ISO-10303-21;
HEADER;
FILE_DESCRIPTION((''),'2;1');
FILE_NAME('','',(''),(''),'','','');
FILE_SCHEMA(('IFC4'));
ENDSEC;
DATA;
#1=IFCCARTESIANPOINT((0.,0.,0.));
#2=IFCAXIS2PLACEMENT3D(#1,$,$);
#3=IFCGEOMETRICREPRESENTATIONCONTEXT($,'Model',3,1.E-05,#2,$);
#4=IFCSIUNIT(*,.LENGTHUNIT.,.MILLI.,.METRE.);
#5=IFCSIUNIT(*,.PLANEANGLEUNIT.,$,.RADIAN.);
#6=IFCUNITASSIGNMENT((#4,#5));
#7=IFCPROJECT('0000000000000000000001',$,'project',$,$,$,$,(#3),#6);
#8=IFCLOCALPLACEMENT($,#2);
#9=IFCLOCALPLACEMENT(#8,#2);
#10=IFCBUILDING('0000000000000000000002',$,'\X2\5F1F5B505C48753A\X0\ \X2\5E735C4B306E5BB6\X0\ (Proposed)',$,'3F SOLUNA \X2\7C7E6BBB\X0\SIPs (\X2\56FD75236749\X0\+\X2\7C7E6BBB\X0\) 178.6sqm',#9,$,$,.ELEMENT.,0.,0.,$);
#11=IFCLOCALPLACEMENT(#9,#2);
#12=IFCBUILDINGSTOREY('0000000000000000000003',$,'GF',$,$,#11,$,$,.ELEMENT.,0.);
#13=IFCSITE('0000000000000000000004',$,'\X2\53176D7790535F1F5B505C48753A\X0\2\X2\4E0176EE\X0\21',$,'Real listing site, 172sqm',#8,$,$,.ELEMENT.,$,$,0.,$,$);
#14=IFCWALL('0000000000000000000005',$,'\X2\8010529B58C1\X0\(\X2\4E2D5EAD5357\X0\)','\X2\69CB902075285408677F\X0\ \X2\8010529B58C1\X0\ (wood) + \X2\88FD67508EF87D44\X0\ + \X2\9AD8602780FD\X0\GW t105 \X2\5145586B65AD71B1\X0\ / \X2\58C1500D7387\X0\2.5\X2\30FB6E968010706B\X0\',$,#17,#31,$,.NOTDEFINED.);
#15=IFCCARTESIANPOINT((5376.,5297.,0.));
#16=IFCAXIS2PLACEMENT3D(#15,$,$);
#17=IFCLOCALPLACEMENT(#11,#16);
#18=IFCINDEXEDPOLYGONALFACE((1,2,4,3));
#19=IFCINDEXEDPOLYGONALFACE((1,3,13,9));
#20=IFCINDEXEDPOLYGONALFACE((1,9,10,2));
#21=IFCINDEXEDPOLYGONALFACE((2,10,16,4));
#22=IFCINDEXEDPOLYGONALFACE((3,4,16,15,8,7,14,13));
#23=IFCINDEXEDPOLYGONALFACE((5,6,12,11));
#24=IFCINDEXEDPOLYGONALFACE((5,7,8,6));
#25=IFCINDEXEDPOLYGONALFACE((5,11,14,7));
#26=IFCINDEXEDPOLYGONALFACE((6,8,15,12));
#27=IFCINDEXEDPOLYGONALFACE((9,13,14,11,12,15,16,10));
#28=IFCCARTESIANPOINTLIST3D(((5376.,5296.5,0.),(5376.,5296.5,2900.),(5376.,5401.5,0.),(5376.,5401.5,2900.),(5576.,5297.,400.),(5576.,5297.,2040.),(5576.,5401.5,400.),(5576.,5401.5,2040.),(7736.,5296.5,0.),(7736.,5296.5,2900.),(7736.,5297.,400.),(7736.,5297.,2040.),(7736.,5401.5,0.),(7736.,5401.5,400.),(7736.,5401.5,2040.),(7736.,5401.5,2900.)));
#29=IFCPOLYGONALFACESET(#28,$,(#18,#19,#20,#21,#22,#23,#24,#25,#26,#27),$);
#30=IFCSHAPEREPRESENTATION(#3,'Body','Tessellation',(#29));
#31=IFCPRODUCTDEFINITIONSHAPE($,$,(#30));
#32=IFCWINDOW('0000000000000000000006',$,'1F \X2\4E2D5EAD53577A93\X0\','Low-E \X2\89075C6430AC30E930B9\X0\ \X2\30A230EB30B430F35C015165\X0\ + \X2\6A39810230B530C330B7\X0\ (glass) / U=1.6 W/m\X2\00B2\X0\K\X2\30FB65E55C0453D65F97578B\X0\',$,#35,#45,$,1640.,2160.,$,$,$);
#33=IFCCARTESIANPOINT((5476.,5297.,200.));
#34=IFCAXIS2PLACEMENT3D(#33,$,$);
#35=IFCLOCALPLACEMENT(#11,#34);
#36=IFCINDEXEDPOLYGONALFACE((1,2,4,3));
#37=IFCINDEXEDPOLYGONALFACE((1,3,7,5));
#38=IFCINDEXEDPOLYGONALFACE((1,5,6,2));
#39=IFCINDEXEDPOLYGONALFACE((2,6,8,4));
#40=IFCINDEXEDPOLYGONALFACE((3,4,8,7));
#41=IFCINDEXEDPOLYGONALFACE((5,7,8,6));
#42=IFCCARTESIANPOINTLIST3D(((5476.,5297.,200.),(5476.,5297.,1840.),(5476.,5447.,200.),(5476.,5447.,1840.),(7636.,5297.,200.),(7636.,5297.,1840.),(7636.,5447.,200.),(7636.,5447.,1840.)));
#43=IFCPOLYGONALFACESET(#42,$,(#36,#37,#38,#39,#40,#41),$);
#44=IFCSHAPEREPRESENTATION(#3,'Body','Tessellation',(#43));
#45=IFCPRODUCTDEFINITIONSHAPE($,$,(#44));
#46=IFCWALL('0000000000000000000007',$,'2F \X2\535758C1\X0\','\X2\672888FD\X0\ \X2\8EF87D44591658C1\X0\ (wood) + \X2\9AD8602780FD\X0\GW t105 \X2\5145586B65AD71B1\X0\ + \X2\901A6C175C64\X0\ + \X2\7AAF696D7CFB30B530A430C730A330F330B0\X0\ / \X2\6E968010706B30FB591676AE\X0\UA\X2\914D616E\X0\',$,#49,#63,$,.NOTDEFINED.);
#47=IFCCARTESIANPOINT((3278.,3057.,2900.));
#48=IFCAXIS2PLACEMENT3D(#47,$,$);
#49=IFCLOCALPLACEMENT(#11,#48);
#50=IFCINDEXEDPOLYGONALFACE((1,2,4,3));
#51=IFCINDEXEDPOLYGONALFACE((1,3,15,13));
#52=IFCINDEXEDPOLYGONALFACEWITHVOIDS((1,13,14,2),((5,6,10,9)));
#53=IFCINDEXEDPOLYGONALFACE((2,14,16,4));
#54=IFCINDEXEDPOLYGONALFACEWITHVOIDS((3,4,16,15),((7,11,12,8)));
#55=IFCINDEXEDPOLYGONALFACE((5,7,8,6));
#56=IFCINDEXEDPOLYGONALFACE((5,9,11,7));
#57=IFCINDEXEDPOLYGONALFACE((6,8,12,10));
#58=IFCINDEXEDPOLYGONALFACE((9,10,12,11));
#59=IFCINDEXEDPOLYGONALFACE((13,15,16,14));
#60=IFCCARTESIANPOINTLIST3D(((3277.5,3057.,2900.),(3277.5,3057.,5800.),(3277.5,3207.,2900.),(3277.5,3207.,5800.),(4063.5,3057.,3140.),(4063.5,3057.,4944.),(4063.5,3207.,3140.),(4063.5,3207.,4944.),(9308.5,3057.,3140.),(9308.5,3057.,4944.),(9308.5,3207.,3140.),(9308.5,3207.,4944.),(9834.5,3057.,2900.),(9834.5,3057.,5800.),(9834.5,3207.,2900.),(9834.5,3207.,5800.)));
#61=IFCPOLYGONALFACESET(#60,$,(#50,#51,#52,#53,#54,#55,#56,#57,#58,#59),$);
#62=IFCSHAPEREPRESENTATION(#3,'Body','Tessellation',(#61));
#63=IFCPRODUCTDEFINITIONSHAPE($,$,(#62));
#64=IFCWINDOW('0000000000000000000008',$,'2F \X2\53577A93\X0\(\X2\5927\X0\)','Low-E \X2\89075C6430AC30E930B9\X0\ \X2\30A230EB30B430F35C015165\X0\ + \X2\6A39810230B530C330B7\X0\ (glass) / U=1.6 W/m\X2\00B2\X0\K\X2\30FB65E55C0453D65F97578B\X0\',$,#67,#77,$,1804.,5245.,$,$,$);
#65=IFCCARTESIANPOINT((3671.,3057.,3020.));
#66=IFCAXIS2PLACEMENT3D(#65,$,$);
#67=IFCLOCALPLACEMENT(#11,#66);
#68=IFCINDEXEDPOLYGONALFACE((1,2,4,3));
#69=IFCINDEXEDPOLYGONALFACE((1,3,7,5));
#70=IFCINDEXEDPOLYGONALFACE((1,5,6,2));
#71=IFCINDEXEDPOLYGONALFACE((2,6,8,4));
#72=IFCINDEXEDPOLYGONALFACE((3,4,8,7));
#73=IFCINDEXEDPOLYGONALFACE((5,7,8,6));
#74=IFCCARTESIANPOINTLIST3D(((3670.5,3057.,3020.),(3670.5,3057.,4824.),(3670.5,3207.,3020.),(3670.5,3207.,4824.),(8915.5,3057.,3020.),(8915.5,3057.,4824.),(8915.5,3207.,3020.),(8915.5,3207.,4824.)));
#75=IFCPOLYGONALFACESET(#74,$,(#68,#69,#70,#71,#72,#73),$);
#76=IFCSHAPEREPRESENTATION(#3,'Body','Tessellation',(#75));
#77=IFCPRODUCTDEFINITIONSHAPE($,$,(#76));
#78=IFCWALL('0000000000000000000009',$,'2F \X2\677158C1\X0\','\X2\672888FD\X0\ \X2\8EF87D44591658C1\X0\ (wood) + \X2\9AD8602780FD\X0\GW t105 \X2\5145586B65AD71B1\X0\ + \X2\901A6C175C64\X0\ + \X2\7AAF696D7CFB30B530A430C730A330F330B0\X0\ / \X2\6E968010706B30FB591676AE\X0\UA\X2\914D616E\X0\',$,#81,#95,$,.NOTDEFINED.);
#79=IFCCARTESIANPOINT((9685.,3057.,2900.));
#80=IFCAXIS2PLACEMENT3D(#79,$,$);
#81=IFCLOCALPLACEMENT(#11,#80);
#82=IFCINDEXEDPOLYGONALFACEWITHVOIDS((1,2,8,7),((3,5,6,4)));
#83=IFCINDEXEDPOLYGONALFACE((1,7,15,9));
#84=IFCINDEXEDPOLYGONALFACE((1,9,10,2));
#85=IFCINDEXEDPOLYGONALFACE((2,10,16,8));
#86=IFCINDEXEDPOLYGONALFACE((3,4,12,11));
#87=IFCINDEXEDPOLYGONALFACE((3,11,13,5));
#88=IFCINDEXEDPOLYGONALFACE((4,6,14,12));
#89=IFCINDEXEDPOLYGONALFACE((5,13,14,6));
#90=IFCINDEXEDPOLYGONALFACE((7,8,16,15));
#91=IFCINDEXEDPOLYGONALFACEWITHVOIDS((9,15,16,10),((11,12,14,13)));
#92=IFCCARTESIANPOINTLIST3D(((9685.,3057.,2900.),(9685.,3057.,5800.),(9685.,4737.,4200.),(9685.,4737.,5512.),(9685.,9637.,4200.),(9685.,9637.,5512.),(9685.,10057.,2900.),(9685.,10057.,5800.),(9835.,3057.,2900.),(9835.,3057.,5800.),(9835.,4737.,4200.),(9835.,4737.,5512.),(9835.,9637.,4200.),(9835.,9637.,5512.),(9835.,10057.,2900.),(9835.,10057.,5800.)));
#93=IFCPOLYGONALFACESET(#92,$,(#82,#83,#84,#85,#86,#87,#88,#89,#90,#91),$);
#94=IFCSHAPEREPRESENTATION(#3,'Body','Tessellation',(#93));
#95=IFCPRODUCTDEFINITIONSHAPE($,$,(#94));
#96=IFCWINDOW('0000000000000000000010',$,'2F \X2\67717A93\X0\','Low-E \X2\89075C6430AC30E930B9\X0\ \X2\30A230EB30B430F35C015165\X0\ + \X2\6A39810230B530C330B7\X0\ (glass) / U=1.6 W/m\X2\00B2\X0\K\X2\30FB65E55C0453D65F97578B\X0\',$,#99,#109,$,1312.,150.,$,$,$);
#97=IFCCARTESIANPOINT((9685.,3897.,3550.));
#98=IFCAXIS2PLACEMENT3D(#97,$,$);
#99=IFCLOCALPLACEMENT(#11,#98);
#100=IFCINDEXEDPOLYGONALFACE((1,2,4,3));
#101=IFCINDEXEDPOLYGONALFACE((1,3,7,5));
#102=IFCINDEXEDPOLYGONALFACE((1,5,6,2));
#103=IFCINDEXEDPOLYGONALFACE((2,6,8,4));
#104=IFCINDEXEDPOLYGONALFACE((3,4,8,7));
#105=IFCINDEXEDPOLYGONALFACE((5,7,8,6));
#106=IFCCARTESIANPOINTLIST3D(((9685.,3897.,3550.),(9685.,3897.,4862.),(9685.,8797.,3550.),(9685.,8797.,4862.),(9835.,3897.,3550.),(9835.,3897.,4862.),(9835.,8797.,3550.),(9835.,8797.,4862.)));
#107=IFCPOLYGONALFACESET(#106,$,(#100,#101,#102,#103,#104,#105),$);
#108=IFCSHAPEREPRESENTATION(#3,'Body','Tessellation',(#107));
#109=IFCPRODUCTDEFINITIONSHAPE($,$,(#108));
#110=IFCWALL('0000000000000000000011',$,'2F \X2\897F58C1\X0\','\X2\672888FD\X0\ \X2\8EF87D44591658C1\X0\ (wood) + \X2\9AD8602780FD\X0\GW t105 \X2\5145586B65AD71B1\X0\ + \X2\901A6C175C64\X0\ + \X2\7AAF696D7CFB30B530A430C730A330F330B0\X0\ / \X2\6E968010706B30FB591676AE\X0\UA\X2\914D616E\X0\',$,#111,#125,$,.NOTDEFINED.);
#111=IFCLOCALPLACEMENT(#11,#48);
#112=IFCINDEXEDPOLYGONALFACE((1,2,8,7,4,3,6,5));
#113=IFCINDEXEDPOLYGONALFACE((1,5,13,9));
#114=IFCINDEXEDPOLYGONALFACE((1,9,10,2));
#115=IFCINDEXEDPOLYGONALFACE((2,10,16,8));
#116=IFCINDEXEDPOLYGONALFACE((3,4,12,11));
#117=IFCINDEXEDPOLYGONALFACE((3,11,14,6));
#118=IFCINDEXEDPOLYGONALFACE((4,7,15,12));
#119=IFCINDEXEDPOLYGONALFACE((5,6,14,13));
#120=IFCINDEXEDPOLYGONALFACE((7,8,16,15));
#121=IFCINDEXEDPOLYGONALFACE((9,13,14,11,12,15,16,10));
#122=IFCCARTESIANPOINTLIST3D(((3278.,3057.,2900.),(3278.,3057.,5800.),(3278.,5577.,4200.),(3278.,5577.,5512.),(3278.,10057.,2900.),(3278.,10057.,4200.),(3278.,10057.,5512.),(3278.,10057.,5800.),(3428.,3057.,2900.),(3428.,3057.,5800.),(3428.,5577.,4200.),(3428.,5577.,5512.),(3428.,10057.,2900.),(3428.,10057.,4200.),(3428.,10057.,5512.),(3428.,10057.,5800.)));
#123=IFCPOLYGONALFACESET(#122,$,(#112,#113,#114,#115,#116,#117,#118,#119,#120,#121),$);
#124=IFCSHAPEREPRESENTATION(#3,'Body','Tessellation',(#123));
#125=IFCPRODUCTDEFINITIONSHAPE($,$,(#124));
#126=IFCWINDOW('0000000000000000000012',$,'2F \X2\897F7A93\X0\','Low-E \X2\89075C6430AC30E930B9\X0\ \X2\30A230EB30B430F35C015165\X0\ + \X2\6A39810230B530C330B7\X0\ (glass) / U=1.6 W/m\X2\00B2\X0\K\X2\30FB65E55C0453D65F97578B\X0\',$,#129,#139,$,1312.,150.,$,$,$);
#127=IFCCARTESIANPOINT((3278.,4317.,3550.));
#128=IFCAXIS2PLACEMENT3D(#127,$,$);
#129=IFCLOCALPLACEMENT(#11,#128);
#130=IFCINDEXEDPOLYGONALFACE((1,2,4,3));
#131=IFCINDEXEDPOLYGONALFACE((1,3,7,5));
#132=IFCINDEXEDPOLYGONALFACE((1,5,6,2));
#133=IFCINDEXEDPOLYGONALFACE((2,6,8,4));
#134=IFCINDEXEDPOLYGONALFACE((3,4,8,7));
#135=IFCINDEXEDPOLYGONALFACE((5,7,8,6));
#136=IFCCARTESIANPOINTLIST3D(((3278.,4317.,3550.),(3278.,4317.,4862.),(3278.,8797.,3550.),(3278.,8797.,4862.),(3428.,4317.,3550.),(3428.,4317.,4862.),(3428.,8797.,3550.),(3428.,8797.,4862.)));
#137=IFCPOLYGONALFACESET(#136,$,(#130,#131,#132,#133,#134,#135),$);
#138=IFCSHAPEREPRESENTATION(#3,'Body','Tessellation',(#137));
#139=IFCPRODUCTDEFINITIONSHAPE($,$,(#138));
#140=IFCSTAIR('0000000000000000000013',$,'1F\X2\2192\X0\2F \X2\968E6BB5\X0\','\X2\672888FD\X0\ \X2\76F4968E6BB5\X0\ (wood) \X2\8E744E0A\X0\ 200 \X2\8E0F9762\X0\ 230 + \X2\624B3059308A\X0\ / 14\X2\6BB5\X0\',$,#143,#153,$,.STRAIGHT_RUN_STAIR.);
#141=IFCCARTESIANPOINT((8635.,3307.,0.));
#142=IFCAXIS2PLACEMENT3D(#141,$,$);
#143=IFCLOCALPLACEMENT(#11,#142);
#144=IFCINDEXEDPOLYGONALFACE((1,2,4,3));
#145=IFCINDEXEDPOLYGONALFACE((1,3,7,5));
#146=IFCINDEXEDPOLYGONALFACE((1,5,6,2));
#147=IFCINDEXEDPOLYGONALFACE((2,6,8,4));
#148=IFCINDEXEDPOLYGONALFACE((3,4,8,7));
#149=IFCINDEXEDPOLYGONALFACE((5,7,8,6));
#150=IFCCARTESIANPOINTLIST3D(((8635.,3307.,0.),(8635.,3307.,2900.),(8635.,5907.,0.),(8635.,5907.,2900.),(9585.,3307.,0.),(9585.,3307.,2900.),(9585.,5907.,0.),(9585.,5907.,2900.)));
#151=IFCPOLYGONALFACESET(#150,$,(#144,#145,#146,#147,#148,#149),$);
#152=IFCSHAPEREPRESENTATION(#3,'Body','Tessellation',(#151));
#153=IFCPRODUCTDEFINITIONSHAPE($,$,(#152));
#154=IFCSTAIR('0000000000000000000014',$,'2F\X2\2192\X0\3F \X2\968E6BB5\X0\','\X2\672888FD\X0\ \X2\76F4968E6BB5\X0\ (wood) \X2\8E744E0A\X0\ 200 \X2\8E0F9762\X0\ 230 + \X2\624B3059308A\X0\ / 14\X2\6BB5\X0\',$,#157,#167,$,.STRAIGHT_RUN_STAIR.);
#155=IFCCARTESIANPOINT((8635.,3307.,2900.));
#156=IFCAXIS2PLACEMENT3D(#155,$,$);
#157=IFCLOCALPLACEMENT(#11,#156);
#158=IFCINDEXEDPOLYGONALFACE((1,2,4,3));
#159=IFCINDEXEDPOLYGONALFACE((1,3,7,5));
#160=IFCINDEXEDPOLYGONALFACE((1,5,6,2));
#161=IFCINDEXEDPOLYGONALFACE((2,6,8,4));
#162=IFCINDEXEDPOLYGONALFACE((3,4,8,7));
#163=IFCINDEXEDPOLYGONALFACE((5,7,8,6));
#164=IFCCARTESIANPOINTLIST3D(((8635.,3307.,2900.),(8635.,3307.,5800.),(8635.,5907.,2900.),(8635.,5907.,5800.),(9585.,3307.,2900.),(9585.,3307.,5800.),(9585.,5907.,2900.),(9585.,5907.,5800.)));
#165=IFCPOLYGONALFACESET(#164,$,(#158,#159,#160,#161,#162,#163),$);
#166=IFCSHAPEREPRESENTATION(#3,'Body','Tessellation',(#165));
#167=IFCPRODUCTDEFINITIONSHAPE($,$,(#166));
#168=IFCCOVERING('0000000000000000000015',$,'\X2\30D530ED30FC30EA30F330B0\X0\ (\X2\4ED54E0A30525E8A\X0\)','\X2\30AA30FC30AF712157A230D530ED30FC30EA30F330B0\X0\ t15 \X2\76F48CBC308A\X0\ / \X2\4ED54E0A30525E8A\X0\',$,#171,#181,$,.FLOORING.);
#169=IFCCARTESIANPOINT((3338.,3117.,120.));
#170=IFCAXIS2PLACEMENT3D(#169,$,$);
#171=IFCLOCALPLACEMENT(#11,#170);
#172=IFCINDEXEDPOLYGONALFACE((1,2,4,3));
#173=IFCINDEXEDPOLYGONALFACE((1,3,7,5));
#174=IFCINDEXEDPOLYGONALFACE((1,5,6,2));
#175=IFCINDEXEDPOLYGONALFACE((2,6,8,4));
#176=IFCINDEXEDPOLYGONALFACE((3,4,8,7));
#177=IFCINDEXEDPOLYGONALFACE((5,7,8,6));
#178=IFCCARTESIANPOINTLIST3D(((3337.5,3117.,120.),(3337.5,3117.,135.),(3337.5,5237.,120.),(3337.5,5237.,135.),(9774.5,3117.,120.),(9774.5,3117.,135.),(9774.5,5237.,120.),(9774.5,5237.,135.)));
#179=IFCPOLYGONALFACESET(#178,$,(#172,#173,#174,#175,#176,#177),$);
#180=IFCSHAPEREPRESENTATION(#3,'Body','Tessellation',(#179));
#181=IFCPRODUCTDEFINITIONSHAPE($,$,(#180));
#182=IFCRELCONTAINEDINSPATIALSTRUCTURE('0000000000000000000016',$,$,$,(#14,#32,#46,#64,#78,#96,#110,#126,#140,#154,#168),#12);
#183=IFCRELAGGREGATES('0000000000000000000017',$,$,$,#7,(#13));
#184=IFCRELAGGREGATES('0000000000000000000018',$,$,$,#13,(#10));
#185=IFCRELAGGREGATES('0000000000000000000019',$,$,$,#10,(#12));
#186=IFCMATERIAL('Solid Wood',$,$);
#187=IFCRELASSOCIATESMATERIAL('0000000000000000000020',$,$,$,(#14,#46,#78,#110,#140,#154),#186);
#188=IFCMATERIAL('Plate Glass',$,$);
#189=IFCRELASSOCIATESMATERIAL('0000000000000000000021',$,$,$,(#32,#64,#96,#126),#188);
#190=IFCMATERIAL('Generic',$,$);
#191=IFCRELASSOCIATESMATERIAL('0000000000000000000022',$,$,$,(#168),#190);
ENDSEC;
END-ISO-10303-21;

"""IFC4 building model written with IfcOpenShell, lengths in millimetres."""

from ifc_helpers import new_model, si_unit, frame, frame_2d, origin, place, context, project, spatial, rectangle, extrude, material, element, fill, save


model = new_model("IFC4")

# Units and contexts
model_context = context("Model", 3, precision=1e-05, world=origin())
ifc_project = project(units=[si_unit("LENGTHUNIT", "METRE", prefix="MILLI"), si_unit("PLANEANGLEUNIT", "RADIAN")], contexts=[model_context])

# Site, building, storey
site_placement = place(None, origin())
site = spatial("IfcSite", under=ifc_project, at=site_placement, Name="北海道弟子屈町2丁目21", ObjectType="Real listing site, 172sqm", CompositionType="ELEMENT", RefElevation=0.0)
building_placement = place(site_placement, origin())
building = spatial("IfcBuilding", under=site, at=building_placement, Name="弟子屈町 平屋の家 (Proposed)", ObjectType="3F SOLUNA 籾殻SIPs (国産杉+籾殻) 178.6sqm", CompositionType="ELEMENT", ElevationOfRefHeight=0.0, ElevationOfTerrain=0.0)
storey_placement = place(building_placement, origin())
storey = spatial("IfcBuildingStorey", under=building, at=storey_placement, Name="GF", CompositionType="ELEMENT", Elevation=0.0)

# Shared definitions
ifc_material_1 = material(Name="Solid Wood")
ifc_material_2 = material(Name="Generic")

# Shared definitions
ifc_material_3 = material(Name="Plate Glass")

# Walls, openings, windows
wall_1_placement = place(storey_placement, frame((5376.0, 5297.0, 0.0)))
wall_1 = element("IfcWall", 1, at=wall_1_placement, inside=storey, material=ifc_material_1, Name="耐力壁(中庭南)", Description="構造用合板 耐力壁 (wood) + 製材軸組 + 高性能GW t105 充填断熱 / 壁倍率2.5・準耐火", PredefinedType="NOTDEFINED", context=model_context, shape_type="SweptSolid", body=[
    extrude(rectangle(XDim=2360.0, YDim=105.0, at=frame_2d((1180.0, 52.0))), frame((5376.0, 5297.0, 0.0)), (0.0, 0.0, 1.0), 2900.0),
])
opening_1_placement = place(storey_placement, frame((5476.0, 5297.0, 200.0)))
opening_1 = element("IfcOpeningElement", 2, at=opening_1_placement, cuts=wall_1, PredefinedType="NOTDEFINED", context=model_context, shape_type="SweptSolid", body=[
    extrude(rectangle(XDim=2160.0, YDim=150.0, at=frame_2d((1080.0, 75.0))), frame((5476.0, 5297.0, 200.0)), (0.0, 0.0, 1.0), 1640.0),
])
window_1_placement = place(storey_placement, frame((5476.0, 5297.0, 200.0)))
window_1 = element("IfcWindow", 3, at=window_1_placement, inside=storey, material=ifc_material_3, Name="1F 中庭南窓", Description="Low-E 複層ガラス アルゴン封入 + 樹脂サッシ (glass) / U=1.6 W/m²K・日射取得型", OverallHeight=1640.0, OverallWidth=2160.0, context=model_context, shape_type="SweptSolid", body=[
    extrude(rectangle(XDim=2160.0, YDim=150.0, at=frame_2d((1080.0, 75.0))), frame((5476.0, 5297.0, 200.0)), (0.0, 0.0, 1.0), 1640.0),
])
fill(opening_1, window_1)
wall_2_placement = place(storey_placement, frame((3278.0, 3057.0, 2900.0)))
wall_2 = element("IfcWall", 4, at=wall_2_placement, inside=storey, material=ifc_material_1, Name="2F 南壁", Description="木製 軸組外壁 (wood) + 高性能GW t105 充填断熱 + 通気層 + 窯業系サイディング / 準耐火・外皮UA配慮", PredefinedType="NOTDEFINED", context=model_context, shape_type="SweptSolid", body=[
    extrude(rectangle(XDim=6557.0, YDim=150.0, at=frame_2d((3278.0, 75.0))), frame((3278.0, 3057.0, 2900.0)), (0.0, 0.0, 1.0), 2900.0),
])
opening_2_placement = place(storey_placement, frame((3671.0, 3057.0, 3020.0)))
opening_2 = element("IfcOpeningElement", 5, at=opening_2_placement, cuts=wall_2, PredefinedType="NOTDEFINED", context=model_context, shape_type="SweptSolid", body=[
    extrude(rectangle(XDim=5245.0, YDim=150.0, at=frame_2d((2622.0, 75.0))), frame((3671.0, 3057.0, 3020.0)), (0.0, 0.0, 1.0), 1804.0),
])
window_2_placement = place(storey_placement, frame((3671.0, 3057.0, 3020.0)))
window_2 = element("IfcWindow", 6, at=window_2_placement, inside=storey, material=ifc_material_3, Name="2F 南窓(大)", Description="Low-E 複層ガラス アルゴン封入 + 樹脂サッシ (glass) / U=1.6 W/m²K・日射取得型", OverallHeight=1804.0, OverallWidth=5245.0, context=model_context, shape_type="SweptSolid", body=[
    extrude(rectangle(XDim=5245.0, YDim=150.0, at=frame_2d((2622.0, 75.0))), frame((3671.0, 3057.0, 3020.0)), (0.0, 0.0, 1.0), 1804.0),
])
fill(opening_2, window_2)
wall_3_placement = place(storey_placement, frame((9685.0, 3057.0, 2900.0)))
wall_3 = element("IfcWall", 7, at=wall_3_placement, inside=storey, material=ifc_material_1, Name="2F 東壁", Description="木製 軸組外壁 (wood) + 高性能GW t105 充填断熱 + 通気層 + 窯業系サイディング / 準耐火・外皮UA配慮", PredefinedType="NOTDEFINED", context=model_context, shape_type="SweptSolid", body=[
    extrude(rectangle(XDim=150.0, YDim=7000.0, at=frame_2d((75.0, 3500.0))), frame((9685.0, 3057.0, 2900.0)), (0.0, 0.0, 1.0), 2900.0),
])
opening_3_placement = place(storey_placement, frame((9685.0, 3897.0, 3550.0)))
opening_3 = element("IfcOpeningElement", 8, at=opening_3_placement, cuts=wall_3, PredefinedType="NOTDEFINED", context=model_context, shape_type="SweptSolid", body=[
    extrude(rectangle(XDim=150.0, YDim=4900.0, at=frame_2d((75.0, 2450.0))), frame((9685.0, 3897.0, 3550.0)), (0.0, 0.0, 1.0), 1312.0),
])
window_3_placement = place(storey_placement, frame((9685.0, 3897.0, 3550.0)))
window_3 = element("IfcWindow", 9, at=window_3_placement, inside=storey, material=ifc_material_3, Name="2F 東窓", Description="Low-E 複層ガラス アルゴン封入 + 樹脂サッシ (glass) / U=1.6 W/m²K・日射取得型", OverallHeight=1312.0, OverallWidth=150.0, context=model_context, shape_type="SweptSolid", body=[
    extrude(rectangle(XDim=150.0, YDim=4900.0, at=frame_2d((75.0, 2450.0))), frame((9685.0, 3897.0, 3550.0)), (0.0, 0.0, 1.0), 1312.0),
])
fill(opening_3, window_3)
wall_4_placement = place(storey_placement, frame((3278.0, 3057.0, 2900.0)))
wall_4 = element("IfcWall", 10, at=wall_4_placement, inside=storey, material=ifc_material_1, Name="2F 西壁", Description="木製 軸組外壁 (wood) + 高性能GW t105 充填断熱 + 通気層 + 窯業系サイディング / 準耐火・外皮UA配慮", PredefinedType="NOTDEFINED", context=model_context, shape_type="SweptSolid", body=[
    extrude(rectangle(XDim=150.0, YDim=7000.0, at=frame_2d((75.0, 3500.0))), frame((3278.0, 3057.0, 2900.0)), (0.0, 0.0, 1.0), 2900.0),
])
opening_4_placement = place(storey_placement, frame((3278.0, 4317.0, 3550.0)))
opening_4 = element("IfcOpeningElement", 11, at=opening_4_placement, cuts=wall_4, PredefinedType="NOTDEFINED", context=model_context, shape_type="SweptSolid", body=[
    extrude(rectangle(XDim=150.0, YDim=4480.0, at=frame_2d((75.0, 2240.0))), frame((3278.0, 4317.0, 3550.0)), (0.0, 0.0, 1.0), 1312.0),
])
window_4_placement = place(storey_placement, frame((3278.0, 4317.0, 3550.0)))
window_4 = element("IfcWindow", 12, at=window_4_placement, inside=storey, material=ifc_material_3, Name="2F 西窓", Description="Low-E 複層ガラス アルゴン封入 + 樹脂サッシ (glass) / U=1.6 W/m²K・日射取得型", OverallHeight=1312.0, OverallWidth=150.0, context=model_context, shape_type="SweptSolid", body=[
    extrude(rectangle(XDim=150.0, YDim=4480.0, at=frame_2d((75.0, 2240.0))), frame((3278.0, 4317.0, 3550.0)), (0.0, 0.0, 1.0), 1312.0),
])
fill(opening_4, window_4)

# Stairs
stair_1_placement = place(storey_placement, frame((8635.0, 3307.0, 0.0)))
element("IfcStair", 13, at=stair_1_placement, inside=storey, material=ifc_material_1, Name="1F→2F 階段", Description="木製 直階段 (wood) 蹴上 200 踏面 230 + 手すり / 14段", PredefinedType="STRAIGHT_RUN_STAIR", context=model_context, shape_type="SweptSolid", body=[
    extrude(rectangle(XDim=950.0, YDim=2600.0, at=frame_2d((475.0, 1300.0))), frame((8635.0, 3307.0, 0.0)), (0.0, 0.0, 1.0), 2900.0),
])
stair_2_placement = place(storey_placement, frame((8635.0, 3307.0, 2900.0)))
element("IfcStair", 14, at=stair_2_placement, inside=storey, material=ifc_material_1, Name="2F→3F 階段", Description="木製 直階段 (wood) 蹴上 200 踏面 230 + 手すり / 14段", PredefinedType="STRAIGHT_RUN_STAIR", context=model_context, shape_type="SweptSolid", body=[
    extrude(rectangle(XDim=950.0, YDim=2600.0, at=frame_2d((475.0, 1300.0))), frame((8635.0, 3307.0, 2900.0)), (0.0, 0.0, 1.0), 2900.0),
])

# Covering
covering_placement = place(storey_placement, frame((3338.0, 3117.0, 120.0)))
element("IfcCovering", 15, at=covering_placement, inside=storey, material=ifc_material_2, Name="フローリング (仕上げ床)", Description="オーク無垢フローリング t15 直貼り / 仕上げ床", PredefinedType="FLOORING", context=model_context, shape_type="SweptSolid", body=[
    extrude(rectangle(XDim=6437.0, YDim=2120.0, at=frame_2d((3218.0, 1060.0))), frame((3338.0, 3117.0, 120.0)), (0.0, 0.0, 1.0), 15.0),
])

save(model, "model.ifc")
